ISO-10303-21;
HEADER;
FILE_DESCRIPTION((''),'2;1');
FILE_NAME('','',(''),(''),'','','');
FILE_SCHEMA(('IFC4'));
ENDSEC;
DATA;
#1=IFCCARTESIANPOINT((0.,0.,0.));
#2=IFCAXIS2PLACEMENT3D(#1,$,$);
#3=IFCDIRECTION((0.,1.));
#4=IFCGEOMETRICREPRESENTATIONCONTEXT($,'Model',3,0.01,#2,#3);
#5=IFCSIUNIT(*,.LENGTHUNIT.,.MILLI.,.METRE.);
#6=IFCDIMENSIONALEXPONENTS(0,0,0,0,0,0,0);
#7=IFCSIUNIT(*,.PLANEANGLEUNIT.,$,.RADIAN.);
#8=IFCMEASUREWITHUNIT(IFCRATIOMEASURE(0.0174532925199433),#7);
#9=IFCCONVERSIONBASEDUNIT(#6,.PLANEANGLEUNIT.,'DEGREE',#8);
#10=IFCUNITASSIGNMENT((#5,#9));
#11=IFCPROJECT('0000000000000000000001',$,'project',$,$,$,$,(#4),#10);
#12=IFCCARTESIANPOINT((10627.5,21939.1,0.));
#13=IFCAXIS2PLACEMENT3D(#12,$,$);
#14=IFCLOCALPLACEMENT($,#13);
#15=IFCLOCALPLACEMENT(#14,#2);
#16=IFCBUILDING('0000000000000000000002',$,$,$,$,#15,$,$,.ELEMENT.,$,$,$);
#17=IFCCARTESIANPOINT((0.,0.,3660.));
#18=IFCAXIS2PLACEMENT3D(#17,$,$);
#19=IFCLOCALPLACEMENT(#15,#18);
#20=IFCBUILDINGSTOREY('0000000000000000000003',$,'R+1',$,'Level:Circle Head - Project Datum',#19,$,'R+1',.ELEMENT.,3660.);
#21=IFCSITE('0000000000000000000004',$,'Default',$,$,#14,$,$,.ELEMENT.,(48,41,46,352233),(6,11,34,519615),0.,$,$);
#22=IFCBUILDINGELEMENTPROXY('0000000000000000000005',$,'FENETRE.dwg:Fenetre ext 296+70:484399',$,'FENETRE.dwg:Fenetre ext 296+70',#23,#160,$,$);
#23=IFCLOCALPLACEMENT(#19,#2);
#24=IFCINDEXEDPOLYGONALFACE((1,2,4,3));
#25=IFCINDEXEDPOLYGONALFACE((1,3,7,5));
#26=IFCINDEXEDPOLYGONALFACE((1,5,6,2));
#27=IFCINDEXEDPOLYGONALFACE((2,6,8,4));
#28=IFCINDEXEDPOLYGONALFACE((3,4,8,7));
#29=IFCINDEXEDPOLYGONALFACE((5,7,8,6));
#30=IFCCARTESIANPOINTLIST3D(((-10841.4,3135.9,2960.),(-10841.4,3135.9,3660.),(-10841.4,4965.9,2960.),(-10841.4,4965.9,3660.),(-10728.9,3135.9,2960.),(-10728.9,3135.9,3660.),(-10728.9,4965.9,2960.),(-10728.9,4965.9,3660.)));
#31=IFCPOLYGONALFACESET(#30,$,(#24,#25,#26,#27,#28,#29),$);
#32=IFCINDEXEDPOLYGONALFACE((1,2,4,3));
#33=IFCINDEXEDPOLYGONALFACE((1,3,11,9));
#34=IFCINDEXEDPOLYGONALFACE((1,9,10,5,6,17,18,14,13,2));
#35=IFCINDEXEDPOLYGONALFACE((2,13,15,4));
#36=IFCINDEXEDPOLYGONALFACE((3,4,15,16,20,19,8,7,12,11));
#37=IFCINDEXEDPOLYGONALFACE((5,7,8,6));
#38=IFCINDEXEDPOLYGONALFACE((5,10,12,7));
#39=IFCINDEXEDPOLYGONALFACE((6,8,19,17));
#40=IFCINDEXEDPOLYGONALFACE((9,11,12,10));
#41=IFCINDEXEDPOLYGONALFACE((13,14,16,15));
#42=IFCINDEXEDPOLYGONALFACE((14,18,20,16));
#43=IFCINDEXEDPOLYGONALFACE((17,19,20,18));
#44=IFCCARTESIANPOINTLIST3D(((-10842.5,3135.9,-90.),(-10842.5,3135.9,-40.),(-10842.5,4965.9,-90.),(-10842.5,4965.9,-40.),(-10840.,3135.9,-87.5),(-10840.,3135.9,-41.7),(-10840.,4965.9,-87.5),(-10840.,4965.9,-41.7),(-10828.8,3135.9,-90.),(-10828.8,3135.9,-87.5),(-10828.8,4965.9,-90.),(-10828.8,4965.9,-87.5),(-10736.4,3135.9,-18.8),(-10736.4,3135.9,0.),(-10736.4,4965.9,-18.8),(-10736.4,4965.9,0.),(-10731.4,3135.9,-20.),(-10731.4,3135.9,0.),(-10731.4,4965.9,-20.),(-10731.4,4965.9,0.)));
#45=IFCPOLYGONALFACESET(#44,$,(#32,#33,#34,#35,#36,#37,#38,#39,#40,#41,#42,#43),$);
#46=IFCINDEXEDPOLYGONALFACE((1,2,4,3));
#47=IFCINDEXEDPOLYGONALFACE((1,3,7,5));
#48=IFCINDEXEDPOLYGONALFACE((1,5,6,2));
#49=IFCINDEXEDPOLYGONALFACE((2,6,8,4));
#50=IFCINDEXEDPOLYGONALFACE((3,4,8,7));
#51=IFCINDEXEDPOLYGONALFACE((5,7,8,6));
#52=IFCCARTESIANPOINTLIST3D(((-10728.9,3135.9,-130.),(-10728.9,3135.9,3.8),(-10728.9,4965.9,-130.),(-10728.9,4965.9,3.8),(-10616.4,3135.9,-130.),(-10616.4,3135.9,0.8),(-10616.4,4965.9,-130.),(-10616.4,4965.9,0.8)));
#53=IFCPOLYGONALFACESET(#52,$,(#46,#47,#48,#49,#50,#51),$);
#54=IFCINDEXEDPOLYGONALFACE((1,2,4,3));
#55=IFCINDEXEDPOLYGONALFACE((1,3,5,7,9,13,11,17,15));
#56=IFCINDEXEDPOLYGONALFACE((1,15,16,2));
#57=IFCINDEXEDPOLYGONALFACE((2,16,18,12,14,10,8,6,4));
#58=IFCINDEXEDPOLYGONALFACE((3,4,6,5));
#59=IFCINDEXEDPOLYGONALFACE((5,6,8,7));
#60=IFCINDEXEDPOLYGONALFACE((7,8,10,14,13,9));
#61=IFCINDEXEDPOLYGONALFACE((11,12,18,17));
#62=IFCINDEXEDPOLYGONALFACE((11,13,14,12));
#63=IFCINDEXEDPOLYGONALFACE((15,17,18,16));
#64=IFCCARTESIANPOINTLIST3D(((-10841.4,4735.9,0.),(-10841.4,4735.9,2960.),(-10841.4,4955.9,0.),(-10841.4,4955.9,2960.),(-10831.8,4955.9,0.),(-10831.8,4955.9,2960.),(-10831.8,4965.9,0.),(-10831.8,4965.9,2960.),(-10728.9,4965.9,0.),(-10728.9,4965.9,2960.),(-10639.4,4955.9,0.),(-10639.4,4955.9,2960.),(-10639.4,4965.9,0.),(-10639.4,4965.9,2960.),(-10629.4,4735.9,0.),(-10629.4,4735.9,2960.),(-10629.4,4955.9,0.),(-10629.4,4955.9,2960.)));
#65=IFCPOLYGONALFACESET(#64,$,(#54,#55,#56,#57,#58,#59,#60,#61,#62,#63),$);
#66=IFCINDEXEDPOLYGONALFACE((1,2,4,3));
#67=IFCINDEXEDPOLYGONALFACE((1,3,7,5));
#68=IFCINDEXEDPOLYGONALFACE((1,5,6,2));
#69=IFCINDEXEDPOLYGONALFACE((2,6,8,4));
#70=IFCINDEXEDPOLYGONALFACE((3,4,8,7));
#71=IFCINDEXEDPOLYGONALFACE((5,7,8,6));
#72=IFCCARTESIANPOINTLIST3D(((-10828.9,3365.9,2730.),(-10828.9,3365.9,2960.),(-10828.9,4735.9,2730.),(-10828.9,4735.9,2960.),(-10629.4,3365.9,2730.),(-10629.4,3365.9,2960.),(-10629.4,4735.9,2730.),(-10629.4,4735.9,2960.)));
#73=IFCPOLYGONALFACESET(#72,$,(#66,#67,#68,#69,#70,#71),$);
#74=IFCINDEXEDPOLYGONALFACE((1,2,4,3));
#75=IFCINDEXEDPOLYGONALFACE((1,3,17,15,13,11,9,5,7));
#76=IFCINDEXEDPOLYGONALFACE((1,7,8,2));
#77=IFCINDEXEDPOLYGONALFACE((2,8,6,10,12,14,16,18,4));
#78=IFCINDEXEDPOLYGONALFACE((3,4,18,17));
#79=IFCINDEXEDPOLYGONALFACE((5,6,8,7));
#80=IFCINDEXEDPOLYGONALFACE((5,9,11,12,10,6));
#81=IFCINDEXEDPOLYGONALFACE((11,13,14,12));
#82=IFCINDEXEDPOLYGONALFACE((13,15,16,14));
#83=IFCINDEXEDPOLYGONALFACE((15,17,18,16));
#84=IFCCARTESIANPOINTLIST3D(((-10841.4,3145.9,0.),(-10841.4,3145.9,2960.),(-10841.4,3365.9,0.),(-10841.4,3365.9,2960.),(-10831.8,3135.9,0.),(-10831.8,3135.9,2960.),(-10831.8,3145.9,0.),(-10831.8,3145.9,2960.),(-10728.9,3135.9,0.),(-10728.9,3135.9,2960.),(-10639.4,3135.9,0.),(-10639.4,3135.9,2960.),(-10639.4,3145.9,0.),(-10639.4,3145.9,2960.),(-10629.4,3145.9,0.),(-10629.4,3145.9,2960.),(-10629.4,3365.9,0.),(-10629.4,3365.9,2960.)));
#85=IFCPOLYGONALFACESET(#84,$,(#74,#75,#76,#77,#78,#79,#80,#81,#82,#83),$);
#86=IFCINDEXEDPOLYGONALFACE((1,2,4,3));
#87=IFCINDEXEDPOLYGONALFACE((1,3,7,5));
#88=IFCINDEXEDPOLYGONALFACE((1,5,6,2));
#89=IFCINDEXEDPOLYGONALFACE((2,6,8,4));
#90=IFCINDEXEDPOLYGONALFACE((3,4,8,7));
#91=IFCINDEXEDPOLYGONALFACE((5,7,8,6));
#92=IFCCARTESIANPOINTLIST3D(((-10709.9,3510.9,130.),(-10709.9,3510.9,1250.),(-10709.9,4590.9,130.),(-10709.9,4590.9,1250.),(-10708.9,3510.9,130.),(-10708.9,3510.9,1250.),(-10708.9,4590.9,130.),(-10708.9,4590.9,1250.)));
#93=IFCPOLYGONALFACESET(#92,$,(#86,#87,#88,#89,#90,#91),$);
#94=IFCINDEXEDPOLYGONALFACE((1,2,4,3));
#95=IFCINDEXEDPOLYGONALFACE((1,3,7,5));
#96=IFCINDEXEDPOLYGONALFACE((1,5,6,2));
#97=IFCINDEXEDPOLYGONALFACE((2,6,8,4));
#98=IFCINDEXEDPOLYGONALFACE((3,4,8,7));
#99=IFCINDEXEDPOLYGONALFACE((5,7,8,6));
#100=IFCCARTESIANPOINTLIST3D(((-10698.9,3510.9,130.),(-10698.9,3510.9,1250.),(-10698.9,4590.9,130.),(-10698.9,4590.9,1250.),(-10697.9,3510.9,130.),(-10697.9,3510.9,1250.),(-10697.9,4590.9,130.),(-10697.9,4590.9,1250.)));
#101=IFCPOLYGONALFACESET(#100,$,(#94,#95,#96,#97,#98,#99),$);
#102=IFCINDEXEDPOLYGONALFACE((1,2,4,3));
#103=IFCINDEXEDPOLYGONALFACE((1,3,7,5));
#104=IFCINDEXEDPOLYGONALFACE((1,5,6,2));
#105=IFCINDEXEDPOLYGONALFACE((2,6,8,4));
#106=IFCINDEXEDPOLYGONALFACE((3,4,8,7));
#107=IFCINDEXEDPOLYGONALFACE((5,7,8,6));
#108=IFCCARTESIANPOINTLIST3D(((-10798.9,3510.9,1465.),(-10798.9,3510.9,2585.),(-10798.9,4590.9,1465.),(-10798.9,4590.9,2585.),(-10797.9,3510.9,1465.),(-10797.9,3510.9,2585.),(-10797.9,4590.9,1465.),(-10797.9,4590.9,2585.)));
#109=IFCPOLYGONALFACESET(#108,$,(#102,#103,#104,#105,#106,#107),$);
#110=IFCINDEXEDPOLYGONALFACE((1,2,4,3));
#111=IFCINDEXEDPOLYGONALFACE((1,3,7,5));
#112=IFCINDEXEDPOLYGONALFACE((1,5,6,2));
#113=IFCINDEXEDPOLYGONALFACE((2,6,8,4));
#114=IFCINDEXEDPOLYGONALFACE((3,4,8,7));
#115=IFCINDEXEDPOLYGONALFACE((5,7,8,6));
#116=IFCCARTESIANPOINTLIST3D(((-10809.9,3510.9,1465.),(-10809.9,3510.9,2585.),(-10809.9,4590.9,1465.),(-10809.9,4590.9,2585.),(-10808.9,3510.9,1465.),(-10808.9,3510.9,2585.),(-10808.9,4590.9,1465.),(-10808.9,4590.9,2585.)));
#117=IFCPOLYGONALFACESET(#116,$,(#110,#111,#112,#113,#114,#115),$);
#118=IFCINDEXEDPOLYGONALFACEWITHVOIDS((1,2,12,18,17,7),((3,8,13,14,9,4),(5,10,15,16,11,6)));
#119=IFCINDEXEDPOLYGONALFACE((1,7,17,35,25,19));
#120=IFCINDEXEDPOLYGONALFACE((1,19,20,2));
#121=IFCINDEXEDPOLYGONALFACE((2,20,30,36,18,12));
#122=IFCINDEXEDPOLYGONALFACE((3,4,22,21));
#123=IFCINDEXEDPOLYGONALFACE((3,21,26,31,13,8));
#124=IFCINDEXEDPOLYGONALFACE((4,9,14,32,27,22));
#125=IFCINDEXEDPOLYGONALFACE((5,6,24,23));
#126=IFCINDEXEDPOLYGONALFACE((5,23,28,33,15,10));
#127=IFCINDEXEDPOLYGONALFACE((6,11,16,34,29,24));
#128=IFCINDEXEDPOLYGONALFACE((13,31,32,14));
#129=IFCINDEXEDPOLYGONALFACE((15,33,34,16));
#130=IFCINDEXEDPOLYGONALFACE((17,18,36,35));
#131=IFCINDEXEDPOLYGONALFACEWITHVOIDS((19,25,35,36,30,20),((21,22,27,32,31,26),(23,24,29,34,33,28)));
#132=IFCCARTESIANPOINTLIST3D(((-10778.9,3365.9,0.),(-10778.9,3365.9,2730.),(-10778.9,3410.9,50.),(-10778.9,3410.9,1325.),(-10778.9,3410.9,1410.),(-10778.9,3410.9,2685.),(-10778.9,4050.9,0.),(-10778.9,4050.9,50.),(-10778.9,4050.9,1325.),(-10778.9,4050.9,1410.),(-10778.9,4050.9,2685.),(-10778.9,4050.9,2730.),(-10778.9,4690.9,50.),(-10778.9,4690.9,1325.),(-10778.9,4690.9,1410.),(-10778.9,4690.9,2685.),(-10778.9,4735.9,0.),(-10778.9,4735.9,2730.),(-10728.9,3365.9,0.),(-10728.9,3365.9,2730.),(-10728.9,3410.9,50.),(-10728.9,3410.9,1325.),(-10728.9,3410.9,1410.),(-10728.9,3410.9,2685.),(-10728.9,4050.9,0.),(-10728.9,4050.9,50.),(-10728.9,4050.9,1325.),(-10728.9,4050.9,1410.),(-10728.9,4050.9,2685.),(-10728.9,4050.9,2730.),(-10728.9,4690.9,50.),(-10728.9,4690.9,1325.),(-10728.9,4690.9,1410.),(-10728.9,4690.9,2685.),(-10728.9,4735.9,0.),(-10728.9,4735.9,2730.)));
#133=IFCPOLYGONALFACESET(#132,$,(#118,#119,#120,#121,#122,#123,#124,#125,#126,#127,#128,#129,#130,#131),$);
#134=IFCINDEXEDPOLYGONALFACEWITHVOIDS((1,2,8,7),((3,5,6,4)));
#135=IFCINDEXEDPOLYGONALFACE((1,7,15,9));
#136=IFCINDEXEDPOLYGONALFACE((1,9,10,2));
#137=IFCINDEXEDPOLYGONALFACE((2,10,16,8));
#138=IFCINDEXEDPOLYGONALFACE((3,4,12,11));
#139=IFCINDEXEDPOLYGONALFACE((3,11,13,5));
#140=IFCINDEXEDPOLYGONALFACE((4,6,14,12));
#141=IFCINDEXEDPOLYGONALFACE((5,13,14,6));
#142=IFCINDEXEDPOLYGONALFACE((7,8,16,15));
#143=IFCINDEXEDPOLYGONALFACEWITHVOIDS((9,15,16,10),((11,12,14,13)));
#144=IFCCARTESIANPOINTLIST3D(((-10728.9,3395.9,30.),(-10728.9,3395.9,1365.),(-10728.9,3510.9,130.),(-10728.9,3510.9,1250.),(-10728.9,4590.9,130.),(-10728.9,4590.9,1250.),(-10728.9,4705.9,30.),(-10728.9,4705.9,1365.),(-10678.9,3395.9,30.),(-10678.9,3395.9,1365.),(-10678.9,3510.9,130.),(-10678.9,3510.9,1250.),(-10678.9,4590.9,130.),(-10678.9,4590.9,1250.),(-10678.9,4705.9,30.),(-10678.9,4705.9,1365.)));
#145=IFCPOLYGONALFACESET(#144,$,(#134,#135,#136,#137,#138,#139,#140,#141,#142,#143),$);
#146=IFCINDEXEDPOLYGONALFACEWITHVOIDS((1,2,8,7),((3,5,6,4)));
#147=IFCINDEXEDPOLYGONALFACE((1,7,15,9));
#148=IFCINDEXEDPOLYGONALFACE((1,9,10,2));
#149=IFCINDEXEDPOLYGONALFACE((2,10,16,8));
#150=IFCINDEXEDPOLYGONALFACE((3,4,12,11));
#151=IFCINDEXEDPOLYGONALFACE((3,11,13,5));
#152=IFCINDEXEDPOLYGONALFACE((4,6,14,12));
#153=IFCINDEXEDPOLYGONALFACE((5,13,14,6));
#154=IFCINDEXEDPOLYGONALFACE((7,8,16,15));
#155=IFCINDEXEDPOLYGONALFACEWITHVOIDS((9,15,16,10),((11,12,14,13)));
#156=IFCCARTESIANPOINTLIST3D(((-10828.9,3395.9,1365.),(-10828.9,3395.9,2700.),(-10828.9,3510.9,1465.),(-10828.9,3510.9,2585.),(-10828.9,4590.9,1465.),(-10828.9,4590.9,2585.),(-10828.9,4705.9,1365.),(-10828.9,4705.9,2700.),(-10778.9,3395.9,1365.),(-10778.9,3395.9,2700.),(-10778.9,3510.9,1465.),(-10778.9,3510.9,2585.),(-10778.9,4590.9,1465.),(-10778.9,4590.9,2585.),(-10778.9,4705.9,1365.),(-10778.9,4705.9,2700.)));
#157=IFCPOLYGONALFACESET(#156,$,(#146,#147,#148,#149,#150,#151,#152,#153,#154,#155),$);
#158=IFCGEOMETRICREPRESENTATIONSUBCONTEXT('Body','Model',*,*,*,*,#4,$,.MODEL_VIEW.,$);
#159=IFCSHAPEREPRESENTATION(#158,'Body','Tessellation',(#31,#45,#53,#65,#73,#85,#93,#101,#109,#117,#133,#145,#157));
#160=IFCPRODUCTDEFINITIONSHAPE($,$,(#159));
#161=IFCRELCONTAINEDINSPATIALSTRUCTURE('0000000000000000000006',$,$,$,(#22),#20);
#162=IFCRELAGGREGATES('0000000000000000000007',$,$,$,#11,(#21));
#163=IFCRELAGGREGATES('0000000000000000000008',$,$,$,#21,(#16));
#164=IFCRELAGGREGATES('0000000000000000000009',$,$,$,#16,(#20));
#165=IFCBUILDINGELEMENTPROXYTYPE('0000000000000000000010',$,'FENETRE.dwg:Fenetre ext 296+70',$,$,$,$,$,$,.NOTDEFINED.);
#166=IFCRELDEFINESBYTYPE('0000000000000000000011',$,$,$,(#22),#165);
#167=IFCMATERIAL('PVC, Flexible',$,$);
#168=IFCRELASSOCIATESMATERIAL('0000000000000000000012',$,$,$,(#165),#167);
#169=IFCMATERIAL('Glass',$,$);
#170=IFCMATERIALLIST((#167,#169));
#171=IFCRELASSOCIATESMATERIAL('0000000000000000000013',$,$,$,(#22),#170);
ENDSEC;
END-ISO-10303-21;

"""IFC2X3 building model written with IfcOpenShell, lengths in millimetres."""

from ifc_helpers import new_model, entity, si_unit, converted_unit, direction, frame, frame_2d, origin, origin_2d_with_axis, place, context, subcontext, project, spatial, polyline, rectangle, outline, extrude, source, transform, mapped, material, material_list, type_object, type_shapes, element, save


model = new_model("IFC2X3")

# Units and contexts
model_context = context("Model", 3, precision=0.01, world=origin(), true_north=direction((0.0, 1.0)))
body_context = subcontext(model_context, "Body", "Model", "MODEL_VIEW")
ifc_project = project(units=[si_unit("LENGTHUNIT", "METRE", prefix="MILLI"), converted_unit("PLANEANGLEUNIT", "DEGREE", entity("IfcRatioMeasure", 0.0174532925199433), si_unit("PLANEANGLEUNIT", "RADIAN"), dimensions=[0, 0, 0, 0, 0, 0, 0])], contexts=[model_context])

# Site, building, storey
site_placement = place(None, frame((10627.5, 21939.1, 0.0)))
site = spatial("IfcSite", under=ifc_project, at=site_placement, Name="Default", CompositionType="ELEMENT", RefLatitude=(48, 41, 46, 352233), RefLongitude=(6, 11, 34, 519615), RefElevation=0.0)
building_placement = place(site_placement, origin())
building = spatial("IfcBuilding", under=site, at=building_placement, CompositionType="ELEMENT")
storey_placement = place(building_placement, frame((0.0, 0.0, 3660.0)))
storey = spatial("IfcBuildingStorey", under=building, at=storey_placement, Name="R+1", ObjectType="Level:Circle Head - Project Datum", LongName="R+1", CompositionType="ELEMENT", Elevation=3660.0)

# Building element proxy
ifc_material_1 = material(Name="PVC, Flexible")
ifc_material_2 = material(Name="Glass")
building_element_proxy_type_1 = type_object("IfcBuildingElementProxyType", Name="FENETRE.dwg:Fenetre ext 296+70", PredefinedType="NOTDEFINED", material=ifc_material_1)
shared_shape_1 = source(origin(), body_context, "Body", "SweptSolid", [
    extrude(rectangle(XDim=1830.0, YDim=112.5, at=origin_2d_with_axis()), frame((-10.4, 56.3, 2960.0), z_axis=(0.0, 0.0, 1.0), x_axis=(-1.0, 0.0, 0.0)), (0.0, 0.0, 1.0), 700.0),
    extrude(outline(polyline([(-68.6, -14.4), (-72.5, -34.0), (-67.6, -35.0), (-63.9, -16.6), (44.3, -16.6), (54.1, 32.5), (40.6, 35.2), (40.1, 32.7), (51.2, 30.5), (42.2, -14.4), (-68.6, -14.4)])), frame((-925.4, 66.9, -47.5), z_axis=(-1.0, 0.0, 0.0), x_axis=(0.0, 0.980599, -0.196027)), (0.0, 0.0, -1.0), 1830.0),
    extrude(outline(polyline([(-64.7, -56.3), (66.2, -56.3), (66.2, 56.3), (-67.7, 56.3), (-64.7, -56.3)])), frame((-925.4, -56.3, -63.8), z_axis=(1.0, 0.0, 0.0), x_axis=(0.0, 0.0, -1.0)), (0.0, 0.0, 1.0), 1830.0),
    extrude(outline(polyline([(-55.6, 97.0), (-55.6, -5.9), (-55.6, -95.4), (-45.6, -95.4), (-45.6, -105.4), (174.4, -105.4), (174.4, 106.6), (-45.6, 106.6), (-45.6, 97.0), (-55.6, 97.0)])), frame((849.0, 5.9, 0.0), z_axis=(0.0, 0.0, -1.0), x_axis=(-1.0, 0.0, 0.0)), (0.0, 0.0, -1.0), 2960.0),
    extrude(rectangle(XDim=199.5, YDim=1370.0, at=origin_2d_with_axis()), frame((-10.4, 0.3, 2730.0), z_axis=(0.0, 0.0, 1.0), x_axis=(0.0, 1.0, 0.0)), (0.0, 0.0, 1.0), 230.0),
    extrude(outline(polyline([(-97.0, -55.6), (5.9, -55.6), (95.4, -55.6), (95.4, -45.6), (105.4, -45.6), (105.4, 174.4), (-106.6, 174.4), (-106.6, -45.6), (-97.0, -45.6), (-97.0, -55.6)])), frame((-869.9, 5.9, 0.0), z_axis=(0.0, 0.0, 1.0), x_axis=(0.0, -1.0, 0.0)), (0.0, 0.0, 1.0), 2960.0),
    extrude(rectangle(XDim=1.0, YDim=1080.0, at=origin_2d_with_axis()), frame((-10.4, -19.5, 130.0), z_axis=(0.0, 0.0, 1.0), x_axis=(0.0, 1.0, 0.0)), (0.0, 0.0, 1.0), 1120.0),
    extrude(rectangle(XDim=1.0, YDim=1080.0, at=frame_2d((0.0, 0.0), x_axis=(1.0, 0.0))), frame((-10.4, -30.5, 130.0), z_axis=(0.0, 0.0, 1.0), x_axis=(0.0, 1.0, 0.0)), (0.0, 0.0, 1.0), 1120.0),
    extrude(rectangle(XDim=1.0, YDim=1080.0, at=frame_2d((0.0, 0.0), x_axis=(1.0, 0.0))), frame((-10.4, 69.5, 1465.0), z_axis=(0.0, 0.0, 1.0), x_axis=(0.0, 1.0, 0.0)), (0.0, 0.0, 1.0), 1120.0),
    extrude(rectangle(XDim=1.0, YDim=1080.0, at=frame_2d((0.0, 0.0), x_axis=(1.0, 0.0))), frame((-10.4, 80.5, 1465.0), z_axis=(0.0, 0.0, 1.0), x_axis=(0.0, 1.0, 0.0)), (0.0, 0.0, 1.0), 1120.0),
    extrude(outline(polyline([(-685.0, -1365.0), (0.0, -1365.0), (685.0, -1365.0), (685.0, 1365.0), (0.0, 1365.0), (-685.0, 1365.0), (-685.0, -1365.0)]), holes=[polyline([(-640.0, -1320.0), (-640.0, -45.0), (0.0, -45.0), (640.0, -45.0), (640.0, -1320.0), (0.0, -1320.0), (-640.0, -1320.0)]), polyline([(-640.0, 40.0), (-640.0, 1315.0), (0.0, 1315.0), (640.0, 1315.0), (640.0, 40.0), (0.0, 40.0), (-640.0, 40.0)])]), frame((-10.4, 0.0, 1365.0), z_axis=(0.0, 1.0, 0.0), x_axis=(1.0, 0.0, 0.0)), (0.0, 0.0, 1.0), 50.0),
    extrude(outline(polyline([(-655.0, -667.5), (655.0, -667.5), (655.0, 667.5), (-655.0, 667.5), (-655.0, -667.5)]), holes=[polyline([(-540.0, 552.5), (540.0, 552.5), (540.0, -567.5), (-540.0, -567.5), (-540.0, 552.5)])]), frame((-10.4, -50.0, 697.5), z_axis=(0.0, 1.0, 0.0), x_axis=(-1.0, 0.0, 0.0)), (0.0, 0.0, 1.0), 50.0),
    extrude(outline(polyline([(-655.0, -667.5), (655.0, -667.5), (655.0, 667.5), (-655.0, 667.5), (-655.0, -667.5)]), holes=[polyline([(-540.0, 552.5), (540.0, 552.5), (540.0, -567.5), (-540.0, -567.5), (-540.0, 552.5)])]), frame((-10.4, 50.0, 2032.5), z_axis=(0.0, 1.0, 0.0), x_axis=(-1.0, 0.0, 0.0)), (0.0, 0.0, 1.0), 50.0),
])
type_shapes(building_element_proxy_type_1, [shared_shape_1])
ifc_material_list_1 = material_list([ifc_material_1, ifc_material_2])
proxy_1_placement = place(storey_placement, frame((-10728.9, 4061.3, 0.0), z_axis=(0.0, 0.0, 1.0), x_axis=(0.0, 1.0, 0.0)))
element("IfcBuildingElementProxy", 1, at=proxy_1_placement, inside=storey, type_object=building_element_proxy_type_1, material=ifc_material_list_1, Name="FENETRE.dwg:Fenetre ext 296+70:484399", ObjectType="FENETRE.dwg:Fenetre ext 296+70", context=body_context, shape_type="MappedRepresentation", body=[
    mapped(shared_shape_1, transform((0.0, 0.0, 0.0), scale=1.0)),
])

save(model, "model.ifc")
